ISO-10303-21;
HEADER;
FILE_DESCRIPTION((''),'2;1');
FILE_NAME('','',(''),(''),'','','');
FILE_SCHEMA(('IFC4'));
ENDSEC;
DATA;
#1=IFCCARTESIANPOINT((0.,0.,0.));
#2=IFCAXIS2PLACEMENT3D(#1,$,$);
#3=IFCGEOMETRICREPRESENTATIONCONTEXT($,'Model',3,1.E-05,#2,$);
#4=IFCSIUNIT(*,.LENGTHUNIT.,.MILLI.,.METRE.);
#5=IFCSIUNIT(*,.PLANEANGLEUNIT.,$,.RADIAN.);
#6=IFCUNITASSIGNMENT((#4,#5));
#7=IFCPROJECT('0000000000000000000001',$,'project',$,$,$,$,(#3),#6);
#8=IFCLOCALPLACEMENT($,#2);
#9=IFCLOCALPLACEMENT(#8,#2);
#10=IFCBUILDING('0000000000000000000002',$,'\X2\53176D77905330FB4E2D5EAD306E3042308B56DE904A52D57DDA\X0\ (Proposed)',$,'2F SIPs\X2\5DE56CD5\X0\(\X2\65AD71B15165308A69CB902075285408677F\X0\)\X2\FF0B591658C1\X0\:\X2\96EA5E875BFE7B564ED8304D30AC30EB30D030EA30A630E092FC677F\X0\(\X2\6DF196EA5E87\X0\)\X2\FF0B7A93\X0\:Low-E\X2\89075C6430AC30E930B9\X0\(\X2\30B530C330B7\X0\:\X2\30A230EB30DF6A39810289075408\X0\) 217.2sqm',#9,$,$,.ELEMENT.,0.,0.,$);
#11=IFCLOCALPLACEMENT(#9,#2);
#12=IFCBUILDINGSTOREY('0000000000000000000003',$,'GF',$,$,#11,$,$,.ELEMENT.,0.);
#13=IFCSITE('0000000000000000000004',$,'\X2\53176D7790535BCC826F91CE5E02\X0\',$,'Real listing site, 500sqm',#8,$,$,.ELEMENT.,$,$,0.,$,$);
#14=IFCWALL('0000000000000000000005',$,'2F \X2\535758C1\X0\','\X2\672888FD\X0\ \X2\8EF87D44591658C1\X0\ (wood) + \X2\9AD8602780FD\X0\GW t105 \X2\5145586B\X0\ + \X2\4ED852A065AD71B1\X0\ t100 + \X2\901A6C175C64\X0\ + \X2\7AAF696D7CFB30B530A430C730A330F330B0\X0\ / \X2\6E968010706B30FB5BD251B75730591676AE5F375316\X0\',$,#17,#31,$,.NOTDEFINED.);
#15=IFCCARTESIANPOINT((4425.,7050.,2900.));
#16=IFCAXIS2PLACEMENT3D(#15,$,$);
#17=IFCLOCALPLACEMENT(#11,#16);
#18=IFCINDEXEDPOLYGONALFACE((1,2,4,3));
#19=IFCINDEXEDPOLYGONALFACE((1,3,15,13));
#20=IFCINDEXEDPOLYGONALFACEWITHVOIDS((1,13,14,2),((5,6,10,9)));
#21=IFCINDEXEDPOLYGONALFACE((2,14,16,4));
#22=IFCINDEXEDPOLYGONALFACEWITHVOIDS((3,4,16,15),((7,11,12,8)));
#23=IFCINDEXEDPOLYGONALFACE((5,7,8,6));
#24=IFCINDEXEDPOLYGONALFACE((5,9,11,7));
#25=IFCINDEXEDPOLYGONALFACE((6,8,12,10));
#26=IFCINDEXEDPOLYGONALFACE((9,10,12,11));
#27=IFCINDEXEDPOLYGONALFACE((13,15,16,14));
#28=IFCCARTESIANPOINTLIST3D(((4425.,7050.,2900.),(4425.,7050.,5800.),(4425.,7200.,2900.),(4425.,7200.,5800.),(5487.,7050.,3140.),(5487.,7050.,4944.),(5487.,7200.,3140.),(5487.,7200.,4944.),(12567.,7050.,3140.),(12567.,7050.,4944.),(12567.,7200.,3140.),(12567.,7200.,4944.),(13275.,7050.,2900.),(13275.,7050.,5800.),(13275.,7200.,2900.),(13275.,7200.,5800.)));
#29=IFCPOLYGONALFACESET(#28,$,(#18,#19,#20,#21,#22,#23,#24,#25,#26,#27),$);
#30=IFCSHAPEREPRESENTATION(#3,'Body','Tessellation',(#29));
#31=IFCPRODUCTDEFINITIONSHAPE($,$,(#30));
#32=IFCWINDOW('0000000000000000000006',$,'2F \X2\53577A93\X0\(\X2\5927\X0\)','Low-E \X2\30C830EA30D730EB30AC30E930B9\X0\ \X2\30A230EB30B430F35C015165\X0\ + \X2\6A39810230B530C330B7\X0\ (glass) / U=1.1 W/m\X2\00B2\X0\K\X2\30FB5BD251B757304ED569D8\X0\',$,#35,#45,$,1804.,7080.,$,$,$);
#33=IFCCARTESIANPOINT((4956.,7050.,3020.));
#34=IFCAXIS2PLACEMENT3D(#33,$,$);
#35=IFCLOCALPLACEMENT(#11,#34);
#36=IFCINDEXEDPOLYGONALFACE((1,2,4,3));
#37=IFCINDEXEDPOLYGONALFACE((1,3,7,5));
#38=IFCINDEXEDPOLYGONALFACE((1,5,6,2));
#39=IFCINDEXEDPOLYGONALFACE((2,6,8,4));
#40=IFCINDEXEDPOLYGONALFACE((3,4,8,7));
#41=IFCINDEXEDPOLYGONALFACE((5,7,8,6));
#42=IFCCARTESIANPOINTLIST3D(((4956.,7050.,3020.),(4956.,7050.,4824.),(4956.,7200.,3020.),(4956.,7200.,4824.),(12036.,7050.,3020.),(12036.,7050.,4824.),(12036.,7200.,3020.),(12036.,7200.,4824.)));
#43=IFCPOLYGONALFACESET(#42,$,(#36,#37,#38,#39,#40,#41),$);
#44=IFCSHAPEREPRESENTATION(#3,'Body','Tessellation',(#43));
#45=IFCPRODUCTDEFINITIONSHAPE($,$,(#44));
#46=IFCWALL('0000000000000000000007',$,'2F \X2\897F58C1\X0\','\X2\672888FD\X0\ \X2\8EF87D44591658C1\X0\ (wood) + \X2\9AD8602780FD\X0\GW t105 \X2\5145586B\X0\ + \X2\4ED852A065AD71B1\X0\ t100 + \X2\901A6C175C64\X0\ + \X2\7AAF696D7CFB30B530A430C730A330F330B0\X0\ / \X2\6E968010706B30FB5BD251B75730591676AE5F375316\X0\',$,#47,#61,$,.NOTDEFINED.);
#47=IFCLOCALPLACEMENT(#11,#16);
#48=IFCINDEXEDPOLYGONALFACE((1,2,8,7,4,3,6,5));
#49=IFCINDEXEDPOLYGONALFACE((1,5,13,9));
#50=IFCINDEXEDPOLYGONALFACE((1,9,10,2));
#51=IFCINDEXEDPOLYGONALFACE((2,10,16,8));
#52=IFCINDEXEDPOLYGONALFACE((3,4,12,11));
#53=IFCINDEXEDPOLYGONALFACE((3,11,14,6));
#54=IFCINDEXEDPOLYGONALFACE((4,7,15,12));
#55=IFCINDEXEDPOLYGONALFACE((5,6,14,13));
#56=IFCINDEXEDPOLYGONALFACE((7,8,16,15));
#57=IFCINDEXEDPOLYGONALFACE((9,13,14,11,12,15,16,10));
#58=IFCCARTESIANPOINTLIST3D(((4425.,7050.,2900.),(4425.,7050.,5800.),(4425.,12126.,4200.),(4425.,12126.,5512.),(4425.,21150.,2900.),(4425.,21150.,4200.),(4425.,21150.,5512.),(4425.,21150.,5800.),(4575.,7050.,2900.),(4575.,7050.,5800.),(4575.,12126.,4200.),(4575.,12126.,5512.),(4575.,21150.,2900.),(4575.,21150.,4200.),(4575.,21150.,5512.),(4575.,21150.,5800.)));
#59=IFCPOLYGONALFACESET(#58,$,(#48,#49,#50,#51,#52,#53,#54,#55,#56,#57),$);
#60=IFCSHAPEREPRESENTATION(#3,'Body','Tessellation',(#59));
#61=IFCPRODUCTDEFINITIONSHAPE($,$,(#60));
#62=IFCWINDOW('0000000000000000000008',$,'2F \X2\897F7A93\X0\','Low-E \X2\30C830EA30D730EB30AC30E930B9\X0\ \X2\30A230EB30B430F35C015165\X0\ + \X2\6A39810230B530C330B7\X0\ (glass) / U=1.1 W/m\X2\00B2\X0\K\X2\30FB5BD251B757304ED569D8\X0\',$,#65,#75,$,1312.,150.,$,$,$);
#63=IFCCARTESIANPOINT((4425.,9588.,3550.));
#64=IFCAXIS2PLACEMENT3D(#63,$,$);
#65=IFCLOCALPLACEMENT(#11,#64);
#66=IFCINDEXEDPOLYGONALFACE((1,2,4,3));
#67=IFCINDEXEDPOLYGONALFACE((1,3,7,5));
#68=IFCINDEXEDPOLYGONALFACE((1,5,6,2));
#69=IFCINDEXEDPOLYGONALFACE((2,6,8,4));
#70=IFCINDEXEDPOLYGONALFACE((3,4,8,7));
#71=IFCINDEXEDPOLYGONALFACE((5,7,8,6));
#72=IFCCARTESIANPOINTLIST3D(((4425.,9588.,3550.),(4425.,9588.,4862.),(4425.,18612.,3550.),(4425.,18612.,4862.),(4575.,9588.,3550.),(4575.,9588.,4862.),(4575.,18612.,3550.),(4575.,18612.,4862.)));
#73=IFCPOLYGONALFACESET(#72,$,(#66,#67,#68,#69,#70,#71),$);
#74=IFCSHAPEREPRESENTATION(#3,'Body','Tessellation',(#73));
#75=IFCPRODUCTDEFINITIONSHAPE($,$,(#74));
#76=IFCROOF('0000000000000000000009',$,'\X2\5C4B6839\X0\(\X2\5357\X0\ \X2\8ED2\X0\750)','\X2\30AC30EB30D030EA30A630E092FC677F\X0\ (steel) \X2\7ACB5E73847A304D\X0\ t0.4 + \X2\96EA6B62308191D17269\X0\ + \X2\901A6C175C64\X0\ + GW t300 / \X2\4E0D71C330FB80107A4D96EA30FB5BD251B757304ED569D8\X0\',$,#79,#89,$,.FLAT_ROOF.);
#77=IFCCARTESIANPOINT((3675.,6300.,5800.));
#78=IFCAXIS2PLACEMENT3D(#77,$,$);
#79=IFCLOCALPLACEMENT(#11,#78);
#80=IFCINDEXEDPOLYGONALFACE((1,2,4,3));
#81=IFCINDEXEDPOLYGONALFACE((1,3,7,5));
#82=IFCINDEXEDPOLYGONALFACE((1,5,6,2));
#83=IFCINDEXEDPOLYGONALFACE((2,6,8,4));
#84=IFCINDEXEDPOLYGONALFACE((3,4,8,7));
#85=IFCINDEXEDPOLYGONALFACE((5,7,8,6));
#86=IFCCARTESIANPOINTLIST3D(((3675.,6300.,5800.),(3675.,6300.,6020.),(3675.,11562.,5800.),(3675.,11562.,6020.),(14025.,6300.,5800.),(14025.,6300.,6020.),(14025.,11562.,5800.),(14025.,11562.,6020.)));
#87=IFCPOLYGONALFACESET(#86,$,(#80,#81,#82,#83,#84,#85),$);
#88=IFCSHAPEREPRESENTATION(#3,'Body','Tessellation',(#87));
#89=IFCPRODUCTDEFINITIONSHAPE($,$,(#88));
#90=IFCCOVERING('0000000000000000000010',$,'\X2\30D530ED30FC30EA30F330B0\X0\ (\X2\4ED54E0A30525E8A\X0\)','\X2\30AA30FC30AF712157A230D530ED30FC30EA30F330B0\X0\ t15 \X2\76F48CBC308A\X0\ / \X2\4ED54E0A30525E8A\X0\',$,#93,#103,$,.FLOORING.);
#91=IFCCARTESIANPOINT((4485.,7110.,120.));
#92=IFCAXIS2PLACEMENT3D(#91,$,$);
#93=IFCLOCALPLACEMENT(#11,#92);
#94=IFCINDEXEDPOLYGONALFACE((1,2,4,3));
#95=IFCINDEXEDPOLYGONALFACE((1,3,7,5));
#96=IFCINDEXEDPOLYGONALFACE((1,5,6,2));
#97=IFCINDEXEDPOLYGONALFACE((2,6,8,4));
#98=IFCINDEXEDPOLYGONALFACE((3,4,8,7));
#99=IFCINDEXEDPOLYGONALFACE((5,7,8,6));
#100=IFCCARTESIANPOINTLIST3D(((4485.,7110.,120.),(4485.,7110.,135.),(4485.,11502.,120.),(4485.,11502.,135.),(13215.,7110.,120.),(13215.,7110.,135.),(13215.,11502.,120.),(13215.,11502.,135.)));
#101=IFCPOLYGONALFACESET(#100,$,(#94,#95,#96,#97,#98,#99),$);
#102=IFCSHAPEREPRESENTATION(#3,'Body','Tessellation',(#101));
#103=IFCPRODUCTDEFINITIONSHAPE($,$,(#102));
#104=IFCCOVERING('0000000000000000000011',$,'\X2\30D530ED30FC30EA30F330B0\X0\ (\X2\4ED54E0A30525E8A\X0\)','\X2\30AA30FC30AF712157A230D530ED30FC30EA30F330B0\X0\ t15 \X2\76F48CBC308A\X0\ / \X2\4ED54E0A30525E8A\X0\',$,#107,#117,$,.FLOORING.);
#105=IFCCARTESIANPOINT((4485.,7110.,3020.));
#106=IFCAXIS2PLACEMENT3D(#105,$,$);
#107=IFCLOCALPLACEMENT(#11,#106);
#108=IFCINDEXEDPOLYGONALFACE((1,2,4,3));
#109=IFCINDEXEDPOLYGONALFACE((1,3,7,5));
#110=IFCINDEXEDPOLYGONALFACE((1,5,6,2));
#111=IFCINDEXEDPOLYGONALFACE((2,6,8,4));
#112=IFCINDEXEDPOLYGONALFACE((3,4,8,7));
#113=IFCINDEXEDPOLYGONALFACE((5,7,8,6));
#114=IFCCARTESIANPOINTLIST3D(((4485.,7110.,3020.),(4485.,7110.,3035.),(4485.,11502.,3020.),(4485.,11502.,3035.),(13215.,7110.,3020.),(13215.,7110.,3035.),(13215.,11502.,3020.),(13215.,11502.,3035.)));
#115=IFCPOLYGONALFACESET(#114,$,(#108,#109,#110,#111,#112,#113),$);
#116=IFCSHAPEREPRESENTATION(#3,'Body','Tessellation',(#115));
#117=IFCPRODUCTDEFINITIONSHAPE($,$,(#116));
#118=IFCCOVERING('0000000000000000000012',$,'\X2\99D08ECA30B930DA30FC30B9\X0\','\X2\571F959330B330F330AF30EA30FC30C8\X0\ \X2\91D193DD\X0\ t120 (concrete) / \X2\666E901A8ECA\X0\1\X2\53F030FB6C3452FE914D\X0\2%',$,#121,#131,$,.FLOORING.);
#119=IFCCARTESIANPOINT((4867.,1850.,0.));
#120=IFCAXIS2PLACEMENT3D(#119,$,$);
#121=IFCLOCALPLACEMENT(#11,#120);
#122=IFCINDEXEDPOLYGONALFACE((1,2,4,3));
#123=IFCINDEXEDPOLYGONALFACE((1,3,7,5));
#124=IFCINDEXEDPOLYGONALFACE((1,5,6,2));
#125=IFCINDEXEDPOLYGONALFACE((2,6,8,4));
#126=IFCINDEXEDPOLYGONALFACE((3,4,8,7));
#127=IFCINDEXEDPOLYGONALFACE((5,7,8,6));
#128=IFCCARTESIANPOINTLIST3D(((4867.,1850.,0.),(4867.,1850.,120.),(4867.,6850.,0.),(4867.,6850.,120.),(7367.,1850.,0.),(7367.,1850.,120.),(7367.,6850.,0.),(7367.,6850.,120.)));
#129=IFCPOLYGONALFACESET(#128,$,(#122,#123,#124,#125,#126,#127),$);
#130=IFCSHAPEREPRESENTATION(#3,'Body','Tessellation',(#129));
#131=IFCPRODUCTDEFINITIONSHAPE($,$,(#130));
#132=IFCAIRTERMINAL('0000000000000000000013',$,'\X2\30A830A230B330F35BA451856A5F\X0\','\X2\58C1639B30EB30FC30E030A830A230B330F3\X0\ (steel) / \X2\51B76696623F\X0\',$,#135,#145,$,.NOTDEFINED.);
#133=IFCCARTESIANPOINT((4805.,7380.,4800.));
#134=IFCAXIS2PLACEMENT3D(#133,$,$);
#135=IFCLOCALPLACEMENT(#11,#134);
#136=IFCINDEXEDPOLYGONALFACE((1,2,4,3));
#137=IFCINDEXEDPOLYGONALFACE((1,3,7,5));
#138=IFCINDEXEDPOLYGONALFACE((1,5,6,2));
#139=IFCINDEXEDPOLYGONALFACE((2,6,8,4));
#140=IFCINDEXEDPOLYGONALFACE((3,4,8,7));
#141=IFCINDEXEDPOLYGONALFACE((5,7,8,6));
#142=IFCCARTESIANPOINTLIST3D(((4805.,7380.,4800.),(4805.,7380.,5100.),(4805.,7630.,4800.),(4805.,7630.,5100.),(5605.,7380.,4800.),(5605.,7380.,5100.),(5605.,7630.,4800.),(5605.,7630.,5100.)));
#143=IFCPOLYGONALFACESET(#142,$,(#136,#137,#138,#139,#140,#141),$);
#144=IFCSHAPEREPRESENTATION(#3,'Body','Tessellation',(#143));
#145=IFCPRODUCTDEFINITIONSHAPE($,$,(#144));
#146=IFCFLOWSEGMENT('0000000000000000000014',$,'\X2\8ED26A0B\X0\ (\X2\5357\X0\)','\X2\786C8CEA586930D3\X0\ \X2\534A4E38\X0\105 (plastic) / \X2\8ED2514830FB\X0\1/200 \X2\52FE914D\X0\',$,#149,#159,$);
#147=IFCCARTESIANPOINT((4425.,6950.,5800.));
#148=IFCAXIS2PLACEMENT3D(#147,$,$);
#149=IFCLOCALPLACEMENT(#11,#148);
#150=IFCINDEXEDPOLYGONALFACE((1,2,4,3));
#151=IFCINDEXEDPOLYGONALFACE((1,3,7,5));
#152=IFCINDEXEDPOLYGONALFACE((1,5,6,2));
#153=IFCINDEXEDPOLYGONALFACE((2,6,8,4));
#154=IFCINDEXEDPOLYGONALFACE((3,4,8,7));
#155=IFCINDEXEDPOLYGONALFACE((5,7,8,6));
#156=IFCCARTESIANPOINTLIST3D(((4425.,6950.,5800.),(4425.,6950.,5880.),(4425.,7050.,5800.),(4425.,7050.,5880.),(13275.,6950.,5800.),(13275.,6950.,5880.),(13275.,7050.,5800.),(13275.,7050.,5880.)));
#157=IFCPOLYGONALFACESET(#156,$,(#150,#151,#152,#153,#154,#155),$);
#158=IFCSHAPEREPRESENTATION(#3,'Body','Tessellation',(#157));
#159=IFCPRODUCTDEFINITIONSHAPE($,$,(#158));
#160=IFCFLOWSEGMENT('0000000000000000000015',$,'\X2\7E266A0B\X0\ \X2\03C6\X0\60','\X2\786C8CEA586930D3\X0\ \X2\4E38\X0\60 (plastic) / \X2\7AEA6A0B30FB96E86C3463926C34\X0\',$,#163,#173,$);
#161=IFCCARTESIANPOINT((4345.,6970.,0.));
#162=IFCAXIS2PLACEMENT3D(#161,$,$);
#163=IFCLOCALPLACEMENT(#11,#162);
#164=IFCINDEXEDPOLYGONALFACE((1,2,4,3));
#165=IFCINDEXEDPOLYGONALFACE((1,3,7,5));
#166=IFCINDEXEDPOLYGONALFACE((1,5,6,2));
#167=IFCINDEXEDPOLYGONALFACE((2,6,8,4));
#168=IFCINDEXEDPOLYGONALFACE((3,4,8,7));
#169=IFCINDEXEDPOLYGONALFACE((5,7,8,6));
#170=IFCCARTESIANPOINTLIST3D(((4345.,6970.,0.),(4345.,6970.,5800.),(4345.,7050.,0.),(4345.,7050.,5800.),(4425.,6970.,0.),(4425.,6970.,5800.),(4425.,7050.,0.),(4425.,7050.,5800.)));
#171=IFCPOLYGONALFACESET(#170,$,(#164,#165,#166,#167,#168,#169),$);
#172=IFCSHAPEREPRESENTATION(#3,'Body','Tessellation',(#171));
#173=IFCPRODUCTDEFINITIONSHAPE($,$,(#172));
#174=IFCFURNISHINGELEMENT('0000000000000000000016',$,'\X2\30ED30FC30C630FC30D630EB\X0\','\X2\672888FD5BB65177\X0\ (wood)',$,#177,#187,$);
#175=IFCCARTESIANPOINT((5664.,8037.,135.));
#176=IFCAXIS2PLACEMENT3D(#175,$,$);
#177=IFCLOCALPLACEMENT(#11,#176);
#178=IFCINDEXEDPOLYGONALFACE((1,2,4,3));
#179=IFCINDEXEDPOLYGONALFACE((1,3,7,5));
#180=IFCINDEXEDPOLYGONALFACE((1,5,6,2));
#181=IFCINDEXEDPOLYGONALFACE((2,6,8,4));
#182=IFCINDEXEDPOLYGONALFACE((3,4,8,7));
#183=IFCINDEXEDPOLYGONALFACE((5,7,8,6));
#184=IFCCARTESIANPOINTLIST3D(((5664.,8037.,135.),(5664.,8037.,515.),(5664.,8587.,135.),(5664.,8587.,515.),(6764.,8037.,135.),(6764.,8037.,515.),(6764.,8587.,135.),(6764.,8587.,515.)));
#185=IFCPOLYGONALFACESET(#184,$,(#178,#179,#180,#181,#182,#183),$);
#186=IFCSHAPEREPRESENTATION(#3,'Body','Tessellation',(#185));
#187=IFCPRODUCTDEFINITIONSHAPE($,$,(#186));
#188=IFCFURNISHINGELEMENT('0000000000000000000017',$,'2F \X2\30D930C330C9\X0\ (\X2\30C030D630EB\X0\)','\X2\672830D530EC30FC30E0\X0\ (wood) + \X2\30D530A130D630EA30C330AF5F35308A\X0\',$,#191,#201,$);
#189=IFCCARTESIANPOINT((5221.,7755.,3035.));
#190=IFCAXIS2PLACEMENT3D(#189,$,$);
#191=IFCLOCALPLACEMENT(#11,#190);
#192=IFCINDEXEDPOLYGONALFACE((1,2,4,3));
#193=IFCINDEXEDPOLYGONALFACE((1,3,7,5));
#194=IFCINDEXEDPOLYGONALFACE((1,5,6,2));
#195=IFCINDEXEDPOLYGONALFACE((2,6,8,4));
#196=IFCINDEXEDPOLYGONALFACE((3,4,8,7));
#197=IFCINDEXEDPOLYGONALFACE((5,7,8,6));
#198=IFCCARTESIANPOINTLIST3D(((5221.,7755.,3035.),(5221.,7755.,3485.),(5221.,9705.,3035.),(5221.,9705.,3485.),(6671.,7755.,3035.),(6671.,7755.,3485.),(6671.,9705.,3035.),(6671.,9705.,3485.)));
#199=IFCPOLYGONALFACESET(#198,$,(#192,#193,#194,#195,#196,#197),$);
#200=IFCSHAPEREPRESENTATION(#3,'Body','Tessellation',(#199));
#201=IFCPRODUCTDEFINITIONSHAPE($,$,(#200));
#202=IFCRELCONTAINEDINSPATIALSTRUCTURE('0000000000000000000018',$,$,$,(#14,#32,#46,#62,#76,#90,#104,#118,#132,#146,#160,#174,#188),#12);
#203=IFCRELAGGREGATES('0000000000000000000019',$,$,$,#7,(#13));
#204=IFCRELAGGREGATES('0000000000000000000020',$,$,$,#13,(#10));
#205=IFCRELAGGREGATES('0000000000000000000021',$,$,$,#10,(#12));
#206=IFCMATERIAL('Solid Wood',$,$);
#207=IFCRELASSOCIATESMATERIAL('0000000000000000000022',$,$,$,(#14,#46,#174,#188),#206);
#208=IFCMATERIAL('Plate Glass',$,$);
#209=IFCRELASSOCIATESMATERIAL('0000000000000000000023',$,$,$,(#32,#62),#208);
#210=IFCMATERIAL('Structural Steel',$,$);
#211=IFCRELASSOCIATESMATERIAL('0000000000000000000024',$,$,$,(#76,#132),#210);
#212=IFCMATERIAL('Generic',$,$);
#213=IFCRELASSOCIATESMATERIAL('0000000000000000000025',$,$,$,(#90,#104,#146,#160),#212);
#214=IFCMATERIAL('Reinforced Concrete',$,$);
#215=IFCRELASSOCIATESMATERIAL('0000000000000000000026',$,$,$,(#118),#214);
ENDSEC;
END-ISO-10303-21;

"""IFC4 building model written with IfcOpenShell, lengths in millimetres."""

from ifc_helpers import new_model, si_unit, frame, frame_2d, origin, place, context, project, spatial, rectangle, extrude, material, element, fill, save


model = new_model("IFC4")

# Units and contexts
model_context = context("Model", 3, precision=1e-05, world=origin())
ifc_project = project(units=[si_unit("LENGTHUNIT", "METRE", prefix="MILLI"), si_unit("PLANEANGLEUNIT", "RADIAN")], contexts=[model_context])

# Site, building, storey
site_placement = place(None, origin())
site = spatial("IfcSite", under=ifc_project, at=site_placement, Name="北海道富良野市", ObjectType="Real listing site, 500sqm", CompositionType="ELEMENT", RefElevation=0.0)
building_placement = place(site_placement, origin())
building = spatial("IfcBuilding", under=site, at=building_placement, Name="北海道・中庭のある回遊動線 (Proposed)", ObjectType="2F SIPs工法(断熱入り構造用合板)＋外壁:雪庇対策付きガルバリウム鋼板(深雪庇)＋窓:Low-E複層ガラス(サッシ:アルミ樹脂複合) 217.2sqm", CompositionType="ELEMENT", ElevationOfRefHeight=0.0, ElevationOfTerrain=0.0)
storey_placement = place(building_placement, origin())
storey = spatial("IfcBuildingStorey", under=building, at=storey_placement, Name="GF", CompositionType="ELEMENT", Elevation=0.0)

# Shared definitions
ifc_material_1 = material(Name="Solid Wood")

# Shared definitions
ifc_material_2 = material(Name="Reinforced Concrete")

# Shared definitions
ifc_material_3 = material(Name="Plate Glass")

# Walls, openings, windows
wall_1_placement = place(storey_placement, frame((4425.0, 7050.0, 2900.0)))
wall_1 = element("IfcWall", 1, at=wall_1_placement, inside=storey, material=ifc_material_1, Name="2F 南壁", Description="木製 軸組外壁 (wood) + 高性能GW t105 充填 + 付加断熱 t100 + 通気層 + 窯業系サイディング / 準耐火・寒冷地外皮強化", PredefinedType="NOTDEFINED", context=model_context, shape_type="SweptSolid", body=[
    extrude(rectangle(XDim=8850.0, YDim=150.0, at=frame_2d((4425.0, 75.0))), frame((4425.0, 7050.0, 2900.0)), (0.0, 0.0, 1.0), 2900.0),
])
opening_1_placement = place(storey_placement, frame((4956.0, 7050.0, 3020.0)))
opening_1 = element("IfcOpeningElement", 2, at=opening_1_placement, cuts=wall_1, PredefinedType="NOTDEFINED", context=model_context, shape_type="SweptSolid", body=[
    extrude(rectangle(XDim=7080.0, YDim=150.0, at=frame_2d((3540.0, 75.0))), frame((4956.0, 7050.0, 3020.0)), (0.0, 0.0, 1.0), 1804.0),
])
window_1_placement = place(storey_placement, frame((4956.0, 7050.0, 3020.0)))
window_1 = element("IfcWindow", 3, at=window_1_placement, inside=storey, material=ifc_material_3, Name="2F 南窓(大)", Description="Low-E トリプルガラス アルゴン封入 + 樹脂サッシ (glass) / U=1.1 W/m²K・寒冷地仕様", OverallHeight=1804.0, OverallWidth=7080.0, context=model_context, shape_type="SweptSolid", body=[
    extrude(rectangle(XDim=7080.0, YDim=150.0, at=frame_2d((3540.0, 75.0))), frame((4956.0, 7050.0, 3020.0)), (0.0, 0.0, 1.0), 1804.0),
])
fill(opening_1, window_1)
wall_2_placement = place(storey_placement, frame((4425.0, 7050.0, 2900.0)))
wall_2 = element("IfcWall", 4, at=wall_2_placement, inside=storey, material=ifc_material_1, Name="2F 西壁", Description="木製 軸組外壁 (wood) + 高性能GW t105 充填 + 付加断熱 t100 + 通気層 + 窯業系サイディング / 準耐火・寒冷地外皮強化", PredefinedType="NOTDEFINED", context=model_context, shape_type="SweptSolid", body=[
    extrude(rectangle(XDim=150.0, YDim=14100.0, at=frame_2d((75.0, 7050.0))), frame((4425.0, 7050.0, 2900.0)), (0.0, 0.0, 1.0), 2900.0),
])
opening_2_placement = place(storey_placement, frame((4425.0, 9588.0, 3550.0)))
opening_2 = element("IfcOpeningElement", 5, at=opening_2_placement, cuts=wall_2, PredefinedType="NOTDEFINED", context=model_context, shape_type="SweptSolid", body=[
    extrude(rectangle(XDim=150.0, YDim=9024.0, at=frame_2d((75.0, 4512.0))), frame((4425.0, 9588.0, 3550.0)), (0.0, 0.0, 1.0), 1312.0),
])
window_2_placement = place(storey_placement, frame((4425.0, 9588.0, 3550.0)))
window_2 = element("IfcWindow", 6, at=window_2_placement, inside=storey, material=ifc_material_3, Name="2F 西窓", Description="Low-E トリプルガラス アルゴン封入 + 樹脂サッシ (glass) / U=1.1 W/m²K・寒冷地仕様", OverallHeight=1312.0, OverallWidth=150.0, context=model_context, shape_type="SweptSolid", body=[
    extrude(rectangle(XDim=150.0, YDim=9024.0, at=frame_2d((75.0, 4512.0))), frame((4425.0, 9588.0, 3550.0)), (0.0, 0.0, 1.0), 1312.0),
])
fill(opening_2, window_2)

# Roof
ifc_material_4 = material(Name="Structural Steel")
for number, where, name in (
    (7, (3675.0, 6300.0, 5800.0), "屋根(南 軒750)"),
):
    element("IfcRoof", number, at=place(storey_placement, frame(where)), inside=storey, material=ifc_material_4, Name=name, Description="ガルバリウム鋼板 (steel) 立平葺き t0.4 + 雪止め金物 + 通気層 + GW t300 / 不燃・耐積雪・寒冷地仕様", PredefinedType="FLAT_ROOF", context=model_context, shape_type="SweptSolid", body=[
        extrude(rectangle(XDim=10350.0, YDim=5262.0, at=frame_2d((5175.0, 2631.0))), frame((3675.0, 6300.0, 5800.0)), (0.0, 0.0, 1.0), 220.0),
    ])

# Coverings
ifc_material_5 = material(Name="Generic")
covering_1_placement = place(storey_placement, frame((4485.0, 7110.0, 120.0)))
element("IfcCovering", 8, at=covering_1_placement, inside=storey, material=ifc_material_5, Name="フローリング (仕上げ床)", Description="オーク無垢フローリング t15 直貼り / 仕上げ床", PredefinedType="FLOORING", context=model_context, shape_type="SweptSolid", body=[
    extrude(rectangle(XDim=8730.0, YDim=4392.0, at=frame_2d((4365.0, 2196.0))), frame((4485.0, 7110.0, 120.0)), (0.0, 0.0, 1.0), 15.0),
])
covering_2_placement = place(storey_placement, frame((4485.0, 7110.0, 3020.0)))
element("IfcCovering", 9, at=covering_2_placement, inside=storey, material=ifc_material_5, Name="フローリング (仕上げ床)", Description="オーク無垢フローリング t15 直貼り / 仕上げ床", PredefinedType="FLOORING", context=model_context, shape_type="SweptSolid", body=[
    extrude(rectangle(XDim=8730.0, YDim=4392.0, at=frame_2d((4365.0, 2196.0))), frame((4485.0, 7110.0, 3020.0)), (0.0, 0.0, 1.0), 15.0),
])
covering_3_placement = place(storey_placement, frame((4867.0, 1850.0, 0.0)))
element("IfcCovering", 10, at=covering_3_placement, inside=storey, material=ifc_material_2, Name="駐車スペース", Description="土間コンクリート 金鏝 t120 (concrete) / 普通車1台・水勾配2%", PredefinedType="FLOORING", context=model_context, shape_type="SweptSolid", body=[
    extrude(rectangle(XDim=2500.0, YDim=5000.0, at=frame_2d((1250.0, 2500.0))), frame((4867.0, 1850.0, 0.0)), (0.0, 0.0, 1.0), 120.0),
])

# Air terminal
air_terminal_placement = place(storey_placement, frame((4805.0, 7380.0, 4800.0)))
element("IfcAirTerminal", 11, at=air_terminal_placement, inside=storey, material=ifc_material_4, Name="エアコン室内機", Description="壁掛ルームエアコン (steel) / 冷暖房", PredefinedType="NOTDEFINED", context=model_context, shape_type="SweptSolid", body=[
    extrude(rectangle(XDim=800.0, YDim=250.0, at=frame_2d((400.0, 125.0))), frame((4805.0, 7380.0, 4800.0)), (0.0, 0.0, 1.0), 300.0),
])

# Flow segments
flow_segment_1_placement = place(storey_placement, frame((4425.0, 6950.0, 5800.0)))
element("IfcFlowSegment", 12, at=flow_segment_1_placement, inside=storey, material=ifc_material_5, Name="軒樋 (南)", Description="硬質塩ビ 半丸105 (plastic) / 軒先・1/200 勾配", context=model_context, shape_type="SweptSolid", body=[
    extrude(rectangle(XDim=8850.0, YDim=100.0, at=frame_2d((4425.0, 50.0))), frame((4425.0, 6950.0, 5800.0)), (0.0, 0.0, 1.0), 80.0),
])
flow_segment_2_placement = place(storey_placement, frame((4345.0, 6970.0, 0.0)))
element("IfcFlowSegment", 13, at=flow_segment_2_placement, inside=storey, material=ifc_material_5, Name="縦樋 φ60", Description="硬質塩ビ 丸60 (plastic) / 竪樋・雨水排水", context=model_context, shape_type="SweptSolid", body=[
    extrude(rectangle(XDim=80.0, YDim=80.0, at=frame_2d((40.0, 40.0))), frame((4345.0, 6970.0, 0.0)), (0.0, 0.0, 1.0), 5800.0),
])

# Furnishing elements
furnishing_1_placement = place(storey_placement, frame((5664.0, 8037.0, 135.0)))
element("IfcFurnishingElement", 14, at=furnishing_1_placement, inside=storey, material=ifc_material_1, Name="ローテーブル", Description="木製家具 (wood)", context=model_context, shape_type="SweptSolid", body=[
    extrude(rectangle(XDim=1100.0, YDim=550.0, at=frame_2d((550.0, 275.0))), frame((5664.0, 8037.0, 135.0)), (0.0, 0.0, 1.0), 380.0),
])
furnishing_2_placement = place(storey_placement, frame((5221.0, 7755.0, 3035.0)))
element("IfcFurnishingElement", 15, at=furnishing_2_placement, inside=storey, material=ifc_material_1, Name="2F ベッド (ダブル)", Description="木フレーム (wood) + ファブリック張り", context=model_context, shape_type="SweptSolid", body=[
    extrude(rectangle(XDim=1450.0, YDim=1950.0, at=frame_2d((725.0, 975.0))), frame((5221.0, 7755.0, 3035.0)), (0.0, 0.0, 1.0), 450.0),
])

save(model, "model.ifc")
